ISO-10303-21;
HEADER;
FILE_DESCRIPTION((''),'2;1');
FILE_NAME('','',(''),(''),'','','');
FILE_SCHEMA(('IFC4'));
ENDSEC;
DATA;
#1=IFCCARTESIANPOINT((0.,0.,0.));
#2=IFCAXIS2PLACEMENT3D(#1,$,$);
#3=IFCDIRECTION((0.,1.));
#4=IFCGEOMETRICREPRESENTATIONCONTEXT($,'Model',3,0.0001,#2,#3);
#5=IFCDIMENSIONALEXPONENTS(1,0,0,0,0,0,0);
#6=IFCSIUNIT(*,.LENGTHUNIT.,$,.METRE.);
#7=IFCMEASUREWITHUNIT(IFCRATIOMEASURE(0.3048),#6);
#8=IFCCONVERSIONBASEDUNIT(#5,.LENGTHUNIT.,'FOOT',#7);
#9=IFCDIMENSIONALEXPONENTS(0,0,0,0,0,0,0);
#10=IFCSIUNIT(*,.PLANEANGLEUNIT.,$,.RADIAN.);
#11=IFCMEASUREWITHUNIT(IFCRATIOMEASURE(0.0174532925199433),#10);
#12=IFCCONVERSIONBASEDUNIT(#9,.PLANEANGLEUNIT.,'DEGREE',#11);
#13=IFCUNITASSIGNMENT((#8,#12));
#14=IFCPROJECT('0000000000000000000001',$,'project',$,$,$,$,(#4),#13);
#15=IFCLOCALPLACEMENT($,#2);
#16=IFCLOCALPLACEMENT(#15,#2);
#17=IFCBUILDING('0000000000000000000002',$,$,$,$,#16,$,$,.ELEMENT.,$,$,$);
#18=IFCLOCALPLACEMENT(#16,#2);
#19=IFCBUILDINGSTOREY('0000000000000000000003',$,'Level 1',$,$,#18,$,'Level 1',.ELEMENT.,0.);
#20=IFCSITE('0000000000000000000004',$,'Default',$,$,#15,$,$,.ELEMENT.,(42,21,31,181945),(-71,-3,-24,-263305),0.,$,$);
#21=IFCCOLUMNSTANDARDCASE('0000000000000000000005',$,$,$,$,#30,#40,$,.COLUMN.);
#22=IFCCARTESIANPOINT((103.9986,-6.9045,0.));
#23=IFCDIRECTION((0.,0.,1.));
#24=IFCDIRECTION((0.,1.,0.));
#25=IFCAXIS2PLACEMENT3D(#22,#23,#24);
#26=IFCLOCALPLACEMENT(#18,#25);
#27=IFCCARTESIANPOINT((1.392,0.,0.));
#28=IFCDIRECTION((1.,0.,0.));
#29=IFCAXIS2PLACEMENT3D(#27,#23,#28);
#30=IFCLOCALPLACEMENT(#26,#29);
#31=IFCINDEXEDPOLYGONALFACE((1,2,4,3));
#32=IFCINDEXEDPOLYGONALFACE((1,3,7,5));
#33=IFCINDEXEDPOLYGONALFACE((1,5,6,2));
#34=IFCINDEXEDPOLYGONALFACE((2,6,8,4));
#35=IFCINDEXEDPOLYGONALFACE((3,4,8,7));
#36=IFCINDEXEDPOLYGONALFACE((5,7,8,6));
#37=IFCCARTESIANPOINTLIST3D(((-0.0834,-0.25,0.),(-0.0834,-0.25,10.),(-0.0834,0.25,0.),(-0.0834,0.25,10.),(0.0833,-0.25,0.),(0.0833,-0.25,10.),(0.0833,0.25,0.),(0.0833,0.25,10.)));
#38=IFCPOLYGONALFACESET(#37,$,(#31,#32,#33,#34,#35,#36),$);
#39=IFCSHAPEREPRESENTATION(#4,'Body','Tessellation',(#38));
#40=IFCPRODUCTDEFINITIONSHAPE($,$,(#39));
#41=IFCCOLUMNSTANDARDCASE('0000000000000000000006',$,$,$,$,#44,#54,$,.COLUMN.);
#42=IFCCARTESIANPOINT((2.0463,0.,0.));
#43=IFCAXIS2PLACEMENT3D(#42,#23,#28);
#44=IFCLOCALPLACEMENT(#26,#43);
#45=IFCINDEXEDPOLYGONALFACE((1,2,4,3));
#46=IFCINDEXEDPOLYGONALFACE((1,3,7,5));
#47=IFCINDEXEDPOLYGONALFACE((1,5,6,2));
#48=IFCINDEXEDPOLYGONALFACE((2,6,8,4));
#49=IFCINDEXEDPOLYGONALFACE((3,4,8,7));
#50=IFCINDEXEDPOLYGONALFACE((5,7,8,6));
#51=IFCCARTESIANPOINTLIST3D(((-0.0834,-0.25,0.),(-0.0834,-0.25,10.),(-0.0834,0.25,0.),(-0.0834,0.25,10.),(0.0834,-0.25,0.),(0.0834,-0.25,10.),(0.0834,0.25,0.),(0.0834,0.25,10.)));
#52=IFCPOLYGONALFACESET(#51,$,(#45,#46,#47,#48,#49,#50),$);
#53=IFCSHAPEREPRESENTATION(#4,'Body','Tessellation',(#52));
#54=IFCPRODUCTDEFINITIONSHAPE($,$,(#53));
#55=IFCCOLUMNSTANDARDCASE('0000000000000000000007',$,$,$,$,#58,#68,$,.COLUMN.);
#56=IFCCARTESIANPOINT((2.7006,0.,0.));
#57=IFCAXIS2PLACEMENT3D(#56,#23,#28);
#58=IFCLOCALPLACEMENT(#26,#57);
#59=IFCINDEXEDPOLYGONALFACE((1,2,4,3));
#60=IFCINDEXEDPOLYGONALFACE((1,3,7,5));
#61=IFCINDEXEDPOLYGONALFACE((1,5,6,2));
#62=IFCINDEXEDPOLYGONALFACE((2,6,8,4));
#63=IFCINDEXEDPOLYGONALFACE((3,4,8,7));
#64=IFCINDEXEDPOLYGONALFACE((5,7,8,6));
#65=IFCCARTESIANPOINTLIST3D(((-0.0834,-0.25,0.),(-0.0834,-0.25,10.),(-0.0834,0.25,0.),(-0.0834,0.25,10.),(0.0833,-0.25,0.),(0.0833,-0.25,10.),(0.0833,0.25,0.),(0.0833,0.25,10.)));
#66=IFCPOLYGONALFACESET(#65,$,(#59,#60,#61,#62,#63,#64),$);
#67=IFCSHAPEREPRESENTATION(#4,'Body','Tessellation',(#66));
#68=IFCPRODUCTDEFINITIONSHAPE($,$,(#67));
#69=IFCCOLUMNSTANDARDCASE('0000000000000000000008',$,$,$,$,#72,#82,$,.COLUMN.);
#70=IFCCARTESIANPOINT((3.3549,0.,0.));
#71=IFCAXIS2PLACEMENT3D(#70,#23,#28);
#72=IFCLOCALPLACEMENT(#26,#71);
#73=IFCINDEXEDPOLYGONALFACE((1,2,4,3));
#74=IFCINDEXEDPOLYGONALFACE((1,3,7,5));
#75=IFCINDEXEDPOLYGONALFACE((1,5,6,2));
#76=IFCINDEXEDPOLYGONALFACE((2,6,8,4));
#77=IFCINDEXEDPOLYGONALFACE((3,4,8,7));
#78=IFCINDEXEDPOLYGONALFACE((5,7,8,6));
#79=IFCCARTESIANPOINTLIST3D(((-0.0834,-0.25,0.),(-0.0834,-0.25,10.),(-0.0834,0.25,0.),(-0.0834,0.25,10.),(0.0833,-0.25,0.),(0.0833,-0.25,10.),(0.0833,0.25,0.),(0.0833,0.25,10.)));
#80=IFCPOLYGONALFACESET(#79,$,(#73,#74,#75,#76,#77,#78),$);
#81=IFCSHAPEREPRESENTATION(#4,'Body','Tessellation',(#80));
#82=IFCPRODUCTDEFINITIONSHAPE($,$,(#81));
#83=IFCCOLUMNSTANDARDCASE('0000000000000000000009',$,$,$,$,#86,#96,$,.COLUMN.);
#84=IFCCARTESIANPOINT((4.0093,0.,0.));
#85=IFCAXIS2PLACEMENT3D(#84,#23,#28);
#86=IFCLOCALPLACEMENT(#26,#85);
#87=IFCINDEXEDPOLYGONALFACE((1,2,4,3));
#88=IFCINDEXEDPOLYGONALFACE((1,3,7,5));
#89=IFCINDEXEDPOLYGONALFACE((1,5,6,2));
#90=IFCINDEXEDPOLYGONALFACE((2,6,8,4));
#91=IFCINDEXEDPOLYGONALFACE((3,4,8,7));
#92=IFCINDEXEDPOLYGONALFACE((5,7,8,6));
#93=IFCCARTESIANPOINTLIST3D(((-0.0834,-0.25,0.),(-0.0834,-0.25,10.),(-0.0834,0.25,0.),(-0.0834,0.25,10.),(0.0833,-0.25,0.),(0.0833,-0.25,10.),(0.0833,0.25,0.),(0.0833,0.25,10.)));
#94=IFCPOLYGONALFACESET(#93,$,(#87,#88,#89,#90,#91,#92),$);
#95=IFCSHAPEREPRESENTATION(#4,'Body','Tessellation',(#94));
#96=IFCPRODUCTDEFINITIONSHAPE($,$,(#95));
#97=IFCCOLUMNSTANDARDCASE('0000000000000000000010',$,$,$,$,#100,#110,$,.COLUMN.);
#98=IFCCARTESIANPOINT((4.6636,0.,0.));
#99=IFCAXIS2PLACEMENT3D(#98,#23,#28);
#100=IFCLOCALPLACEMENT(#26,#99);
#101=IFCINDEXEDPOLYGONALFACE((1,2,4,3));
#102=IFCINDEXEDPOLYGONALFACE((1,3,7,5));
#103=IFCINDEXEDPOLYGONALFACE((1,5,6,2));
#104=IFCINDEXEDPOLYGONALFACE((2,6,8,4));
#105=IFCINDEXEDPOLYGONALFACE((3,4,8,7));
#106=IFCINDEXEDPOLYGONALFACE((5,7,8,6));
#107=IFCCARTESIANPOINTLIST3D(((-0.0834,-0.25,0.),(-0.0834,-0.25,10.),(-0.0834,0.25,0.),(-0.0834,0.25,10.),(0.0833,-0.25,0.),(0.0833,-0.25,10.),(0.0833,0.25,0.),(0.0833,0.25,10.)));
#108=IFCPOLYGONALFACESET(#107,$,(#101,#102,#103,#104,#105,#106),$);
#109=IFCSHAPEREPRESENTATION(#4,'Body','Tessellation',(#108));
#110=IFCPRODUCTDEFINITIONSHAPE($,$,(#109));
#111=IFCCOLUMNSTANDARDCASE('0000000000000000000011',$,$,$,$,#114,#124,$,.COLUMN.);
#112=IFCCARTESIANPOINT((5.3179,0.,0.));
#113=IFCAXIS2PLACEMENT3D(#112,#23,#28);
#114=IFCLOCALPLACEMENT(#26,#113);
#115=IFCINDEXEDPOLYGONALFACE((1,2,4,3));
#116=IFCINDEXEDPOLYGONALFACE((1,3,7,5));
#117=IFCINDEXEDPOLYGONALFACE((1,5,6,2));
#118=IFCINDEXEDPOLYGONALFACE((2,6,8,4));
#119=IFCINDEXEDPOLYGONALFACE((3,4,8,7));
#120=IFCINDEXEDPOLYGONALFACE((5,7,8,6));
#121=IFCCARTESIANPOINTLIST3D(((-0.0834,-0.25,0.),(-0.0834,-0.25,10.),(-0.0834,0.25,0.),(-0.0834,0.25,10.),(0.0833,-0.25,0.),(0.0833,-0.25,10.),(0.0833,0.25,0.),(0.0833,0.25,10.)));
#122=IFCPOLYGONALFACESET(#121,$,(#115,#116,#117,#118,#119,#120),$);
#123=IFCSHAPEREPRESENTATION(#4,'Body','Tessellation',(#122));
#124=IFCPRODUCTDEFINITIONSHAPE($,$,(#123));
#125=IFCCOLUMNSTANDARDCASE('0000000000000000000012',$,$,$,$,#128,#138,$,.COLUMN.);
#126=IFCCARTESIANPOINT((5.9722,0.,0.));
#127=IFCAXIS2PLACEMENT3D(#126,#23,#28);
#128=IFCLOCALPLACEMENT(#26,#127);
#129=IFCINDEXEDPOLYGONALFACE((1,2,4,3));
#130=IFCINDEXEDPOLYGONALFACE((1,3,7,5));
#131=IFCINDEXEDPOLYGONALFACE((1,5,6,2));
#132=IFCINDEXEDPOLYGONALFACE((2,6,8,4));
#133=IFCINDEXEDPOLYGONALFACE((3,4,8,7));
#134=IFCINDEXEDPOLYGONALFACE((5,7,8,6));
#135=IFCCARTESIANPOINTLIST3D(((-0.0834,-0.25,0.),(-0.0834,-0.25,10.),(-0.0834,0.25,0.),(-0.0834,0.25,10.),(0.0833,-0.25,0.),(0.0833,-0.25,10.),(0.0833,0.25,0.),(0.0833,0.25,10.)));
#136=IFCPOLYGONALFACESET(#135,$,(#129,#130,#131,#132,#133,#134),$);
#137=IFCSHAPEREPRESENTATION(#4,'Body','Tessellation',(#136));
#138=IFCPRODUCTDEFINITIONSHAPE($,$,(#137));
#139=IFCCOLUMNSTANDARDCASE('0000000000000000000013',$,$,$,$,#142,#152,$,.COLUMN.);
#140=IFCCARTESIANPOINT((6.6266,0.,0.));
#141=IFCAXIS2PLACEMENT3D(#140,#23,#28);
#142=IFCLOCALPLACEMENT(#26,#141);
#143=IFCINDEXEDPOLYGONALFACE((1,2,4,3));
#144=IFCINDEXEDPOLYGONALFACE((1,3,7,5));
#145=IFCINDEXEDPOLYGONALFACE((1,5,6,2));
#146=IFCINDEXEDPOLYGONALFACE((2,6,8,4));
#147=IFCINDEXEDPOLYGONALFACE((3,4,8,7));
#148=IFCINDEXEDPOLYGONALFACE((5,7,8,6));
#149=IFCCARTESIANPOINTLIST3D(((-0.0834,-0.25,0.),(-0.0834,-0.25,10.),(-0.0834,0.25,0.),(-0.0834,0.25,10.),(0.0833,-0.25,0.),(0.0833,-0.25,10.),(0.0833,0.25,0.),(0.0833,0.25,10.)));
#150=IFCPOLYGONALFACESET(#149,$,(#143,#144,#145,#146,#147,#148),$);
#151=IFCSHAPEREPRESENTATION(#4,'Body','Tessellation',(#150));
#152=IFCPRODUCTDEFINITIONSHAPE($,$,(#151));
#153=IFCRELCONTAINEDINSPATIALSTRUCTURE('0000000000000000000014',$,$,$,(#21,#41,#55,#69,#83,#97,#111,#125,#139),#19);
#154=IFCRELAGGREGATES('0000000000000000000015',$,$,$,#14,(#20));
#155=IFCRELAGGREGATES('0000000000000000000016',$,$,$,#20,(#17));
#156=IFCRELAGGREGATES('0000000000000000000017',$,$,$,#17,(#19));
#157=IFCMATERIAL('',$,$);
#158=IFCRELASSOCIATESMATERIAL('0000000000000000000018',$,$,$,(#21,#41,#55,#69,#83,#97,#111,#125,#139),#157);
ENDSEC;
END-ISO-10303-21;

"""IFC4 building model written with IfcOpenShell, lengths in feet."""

from ifc_helpers import new_model, entity, si_unit, converted_unit, direction, frame, origin, place, context, project, spatial, rectangle, extrude, material, element, save


model = new_model("IFC4")

# Units and contexts
model_context = context("Model", 3, precision=0.0001, world=origin(), true_north=direction((0.0, 1.0)))
ifc_project = project(units=[converted_unit("LENGTHUNIT", "FOOT", entity("IfcRatioMeasure", 0.3048), si_unit("LENGTHUNIT", "METRE"), dimensions=[1, 0, 0, 0, 0, 0, 0]), converted_unit("PLANEANGLEUNIT", "DEGREE", entity("IfcRatioMeasure", 0.0174532925199433), si_unit("PLANEANGLEUNIT", "RADIAN"), dimensions=[0, 0, 0, 0, 0, 0, 0])], contexts=[model_context])

# Site, building, storey
site_placement = place(None, origin())
site = spatial("IfcSite", under=ifc_project, at=site_placement, Name="Default", CompositionType="ELEMENT", RefLatitude=(42, 21, 31, 181945), RefLongitude=(-71, -3, -24, -263305), RefElevation=0.0)
building_placement = place(site_placement, origin())
building = spatial("IfcBuilding", under=site, at=building_placement, CompositionType="ELEMENT")
storey_placement = place(building_placement, origin())
storey = spatial("IfcBuildingStorey", under=building, at=storey_placement, Name="Level 1", LongName="Level 1", CompositionType="ELEMENT", Elevation=0.0)

# Columns
ifc_material = material(Name="")
placement_1 = place(storey_placement, frame((103.9986, -6.9045, 0.0), z_axis=(0.0, 0.0, 1.0), x_axis=(0.0, 1.0, 0.0)))
for number, where, z_axis, x_axis in (
    (1, (1.392, 0.0, 0.0), (0.0, 0.0, 1.0), (1.0, 0.0, 0.0)),
    (2, (2.0463, 0.0, 0.0), (0.0, 0.0, 1.0), (1.0, 0.0, 0.0)),
    (3, (2.7006, 0.0, 0.0), (0.0, 0.0, 1.0), (1.0, 0.0, 0.0)),
    (4, (3.3549, 0.0, 0.0), (0.0, 0.0, 1.0), (1.0, 0.0, 0.0)),
    (5, (4.0093, 0.0, 0.0), (0.0, 0.0, 1.0), (1.0, 0.0, 0.0)),
    (6, (4.6636, 0.0, 0.0), (0.0, 0.0, 1.0), (1.0, 0.0, 0.0)),
    (7, (5.3179, 0.0, 0.0), (0.0, 0.0, 1.0), (1.0, 0.0, 0.0)),
    (8, (5.9722, 0.0, 0.0), (0.0, 0.0, 1.0), (1.0, 0.0, 0.0)),
    (9, (6.6266, 0.0, 0.0), (0.0, 0.0, 1.0), (1.0, 0.0, 0.0)),
):
    element("IfcColumnStandardCase", number, at=place(placement_1, frame(where, z_axis=z_axis, x_axis=x_axis)), inside=storey, material=ifc_material, PredefinedType="COLUMN", context=model_context, shape_type="SweptSolid", body=[
        extrude(rectangle(XDim=0.1667, YDim=0.5), origin(), (0.0, 0.0, 1.0), 10.0),
    ])

save(model, "model.ifc")
